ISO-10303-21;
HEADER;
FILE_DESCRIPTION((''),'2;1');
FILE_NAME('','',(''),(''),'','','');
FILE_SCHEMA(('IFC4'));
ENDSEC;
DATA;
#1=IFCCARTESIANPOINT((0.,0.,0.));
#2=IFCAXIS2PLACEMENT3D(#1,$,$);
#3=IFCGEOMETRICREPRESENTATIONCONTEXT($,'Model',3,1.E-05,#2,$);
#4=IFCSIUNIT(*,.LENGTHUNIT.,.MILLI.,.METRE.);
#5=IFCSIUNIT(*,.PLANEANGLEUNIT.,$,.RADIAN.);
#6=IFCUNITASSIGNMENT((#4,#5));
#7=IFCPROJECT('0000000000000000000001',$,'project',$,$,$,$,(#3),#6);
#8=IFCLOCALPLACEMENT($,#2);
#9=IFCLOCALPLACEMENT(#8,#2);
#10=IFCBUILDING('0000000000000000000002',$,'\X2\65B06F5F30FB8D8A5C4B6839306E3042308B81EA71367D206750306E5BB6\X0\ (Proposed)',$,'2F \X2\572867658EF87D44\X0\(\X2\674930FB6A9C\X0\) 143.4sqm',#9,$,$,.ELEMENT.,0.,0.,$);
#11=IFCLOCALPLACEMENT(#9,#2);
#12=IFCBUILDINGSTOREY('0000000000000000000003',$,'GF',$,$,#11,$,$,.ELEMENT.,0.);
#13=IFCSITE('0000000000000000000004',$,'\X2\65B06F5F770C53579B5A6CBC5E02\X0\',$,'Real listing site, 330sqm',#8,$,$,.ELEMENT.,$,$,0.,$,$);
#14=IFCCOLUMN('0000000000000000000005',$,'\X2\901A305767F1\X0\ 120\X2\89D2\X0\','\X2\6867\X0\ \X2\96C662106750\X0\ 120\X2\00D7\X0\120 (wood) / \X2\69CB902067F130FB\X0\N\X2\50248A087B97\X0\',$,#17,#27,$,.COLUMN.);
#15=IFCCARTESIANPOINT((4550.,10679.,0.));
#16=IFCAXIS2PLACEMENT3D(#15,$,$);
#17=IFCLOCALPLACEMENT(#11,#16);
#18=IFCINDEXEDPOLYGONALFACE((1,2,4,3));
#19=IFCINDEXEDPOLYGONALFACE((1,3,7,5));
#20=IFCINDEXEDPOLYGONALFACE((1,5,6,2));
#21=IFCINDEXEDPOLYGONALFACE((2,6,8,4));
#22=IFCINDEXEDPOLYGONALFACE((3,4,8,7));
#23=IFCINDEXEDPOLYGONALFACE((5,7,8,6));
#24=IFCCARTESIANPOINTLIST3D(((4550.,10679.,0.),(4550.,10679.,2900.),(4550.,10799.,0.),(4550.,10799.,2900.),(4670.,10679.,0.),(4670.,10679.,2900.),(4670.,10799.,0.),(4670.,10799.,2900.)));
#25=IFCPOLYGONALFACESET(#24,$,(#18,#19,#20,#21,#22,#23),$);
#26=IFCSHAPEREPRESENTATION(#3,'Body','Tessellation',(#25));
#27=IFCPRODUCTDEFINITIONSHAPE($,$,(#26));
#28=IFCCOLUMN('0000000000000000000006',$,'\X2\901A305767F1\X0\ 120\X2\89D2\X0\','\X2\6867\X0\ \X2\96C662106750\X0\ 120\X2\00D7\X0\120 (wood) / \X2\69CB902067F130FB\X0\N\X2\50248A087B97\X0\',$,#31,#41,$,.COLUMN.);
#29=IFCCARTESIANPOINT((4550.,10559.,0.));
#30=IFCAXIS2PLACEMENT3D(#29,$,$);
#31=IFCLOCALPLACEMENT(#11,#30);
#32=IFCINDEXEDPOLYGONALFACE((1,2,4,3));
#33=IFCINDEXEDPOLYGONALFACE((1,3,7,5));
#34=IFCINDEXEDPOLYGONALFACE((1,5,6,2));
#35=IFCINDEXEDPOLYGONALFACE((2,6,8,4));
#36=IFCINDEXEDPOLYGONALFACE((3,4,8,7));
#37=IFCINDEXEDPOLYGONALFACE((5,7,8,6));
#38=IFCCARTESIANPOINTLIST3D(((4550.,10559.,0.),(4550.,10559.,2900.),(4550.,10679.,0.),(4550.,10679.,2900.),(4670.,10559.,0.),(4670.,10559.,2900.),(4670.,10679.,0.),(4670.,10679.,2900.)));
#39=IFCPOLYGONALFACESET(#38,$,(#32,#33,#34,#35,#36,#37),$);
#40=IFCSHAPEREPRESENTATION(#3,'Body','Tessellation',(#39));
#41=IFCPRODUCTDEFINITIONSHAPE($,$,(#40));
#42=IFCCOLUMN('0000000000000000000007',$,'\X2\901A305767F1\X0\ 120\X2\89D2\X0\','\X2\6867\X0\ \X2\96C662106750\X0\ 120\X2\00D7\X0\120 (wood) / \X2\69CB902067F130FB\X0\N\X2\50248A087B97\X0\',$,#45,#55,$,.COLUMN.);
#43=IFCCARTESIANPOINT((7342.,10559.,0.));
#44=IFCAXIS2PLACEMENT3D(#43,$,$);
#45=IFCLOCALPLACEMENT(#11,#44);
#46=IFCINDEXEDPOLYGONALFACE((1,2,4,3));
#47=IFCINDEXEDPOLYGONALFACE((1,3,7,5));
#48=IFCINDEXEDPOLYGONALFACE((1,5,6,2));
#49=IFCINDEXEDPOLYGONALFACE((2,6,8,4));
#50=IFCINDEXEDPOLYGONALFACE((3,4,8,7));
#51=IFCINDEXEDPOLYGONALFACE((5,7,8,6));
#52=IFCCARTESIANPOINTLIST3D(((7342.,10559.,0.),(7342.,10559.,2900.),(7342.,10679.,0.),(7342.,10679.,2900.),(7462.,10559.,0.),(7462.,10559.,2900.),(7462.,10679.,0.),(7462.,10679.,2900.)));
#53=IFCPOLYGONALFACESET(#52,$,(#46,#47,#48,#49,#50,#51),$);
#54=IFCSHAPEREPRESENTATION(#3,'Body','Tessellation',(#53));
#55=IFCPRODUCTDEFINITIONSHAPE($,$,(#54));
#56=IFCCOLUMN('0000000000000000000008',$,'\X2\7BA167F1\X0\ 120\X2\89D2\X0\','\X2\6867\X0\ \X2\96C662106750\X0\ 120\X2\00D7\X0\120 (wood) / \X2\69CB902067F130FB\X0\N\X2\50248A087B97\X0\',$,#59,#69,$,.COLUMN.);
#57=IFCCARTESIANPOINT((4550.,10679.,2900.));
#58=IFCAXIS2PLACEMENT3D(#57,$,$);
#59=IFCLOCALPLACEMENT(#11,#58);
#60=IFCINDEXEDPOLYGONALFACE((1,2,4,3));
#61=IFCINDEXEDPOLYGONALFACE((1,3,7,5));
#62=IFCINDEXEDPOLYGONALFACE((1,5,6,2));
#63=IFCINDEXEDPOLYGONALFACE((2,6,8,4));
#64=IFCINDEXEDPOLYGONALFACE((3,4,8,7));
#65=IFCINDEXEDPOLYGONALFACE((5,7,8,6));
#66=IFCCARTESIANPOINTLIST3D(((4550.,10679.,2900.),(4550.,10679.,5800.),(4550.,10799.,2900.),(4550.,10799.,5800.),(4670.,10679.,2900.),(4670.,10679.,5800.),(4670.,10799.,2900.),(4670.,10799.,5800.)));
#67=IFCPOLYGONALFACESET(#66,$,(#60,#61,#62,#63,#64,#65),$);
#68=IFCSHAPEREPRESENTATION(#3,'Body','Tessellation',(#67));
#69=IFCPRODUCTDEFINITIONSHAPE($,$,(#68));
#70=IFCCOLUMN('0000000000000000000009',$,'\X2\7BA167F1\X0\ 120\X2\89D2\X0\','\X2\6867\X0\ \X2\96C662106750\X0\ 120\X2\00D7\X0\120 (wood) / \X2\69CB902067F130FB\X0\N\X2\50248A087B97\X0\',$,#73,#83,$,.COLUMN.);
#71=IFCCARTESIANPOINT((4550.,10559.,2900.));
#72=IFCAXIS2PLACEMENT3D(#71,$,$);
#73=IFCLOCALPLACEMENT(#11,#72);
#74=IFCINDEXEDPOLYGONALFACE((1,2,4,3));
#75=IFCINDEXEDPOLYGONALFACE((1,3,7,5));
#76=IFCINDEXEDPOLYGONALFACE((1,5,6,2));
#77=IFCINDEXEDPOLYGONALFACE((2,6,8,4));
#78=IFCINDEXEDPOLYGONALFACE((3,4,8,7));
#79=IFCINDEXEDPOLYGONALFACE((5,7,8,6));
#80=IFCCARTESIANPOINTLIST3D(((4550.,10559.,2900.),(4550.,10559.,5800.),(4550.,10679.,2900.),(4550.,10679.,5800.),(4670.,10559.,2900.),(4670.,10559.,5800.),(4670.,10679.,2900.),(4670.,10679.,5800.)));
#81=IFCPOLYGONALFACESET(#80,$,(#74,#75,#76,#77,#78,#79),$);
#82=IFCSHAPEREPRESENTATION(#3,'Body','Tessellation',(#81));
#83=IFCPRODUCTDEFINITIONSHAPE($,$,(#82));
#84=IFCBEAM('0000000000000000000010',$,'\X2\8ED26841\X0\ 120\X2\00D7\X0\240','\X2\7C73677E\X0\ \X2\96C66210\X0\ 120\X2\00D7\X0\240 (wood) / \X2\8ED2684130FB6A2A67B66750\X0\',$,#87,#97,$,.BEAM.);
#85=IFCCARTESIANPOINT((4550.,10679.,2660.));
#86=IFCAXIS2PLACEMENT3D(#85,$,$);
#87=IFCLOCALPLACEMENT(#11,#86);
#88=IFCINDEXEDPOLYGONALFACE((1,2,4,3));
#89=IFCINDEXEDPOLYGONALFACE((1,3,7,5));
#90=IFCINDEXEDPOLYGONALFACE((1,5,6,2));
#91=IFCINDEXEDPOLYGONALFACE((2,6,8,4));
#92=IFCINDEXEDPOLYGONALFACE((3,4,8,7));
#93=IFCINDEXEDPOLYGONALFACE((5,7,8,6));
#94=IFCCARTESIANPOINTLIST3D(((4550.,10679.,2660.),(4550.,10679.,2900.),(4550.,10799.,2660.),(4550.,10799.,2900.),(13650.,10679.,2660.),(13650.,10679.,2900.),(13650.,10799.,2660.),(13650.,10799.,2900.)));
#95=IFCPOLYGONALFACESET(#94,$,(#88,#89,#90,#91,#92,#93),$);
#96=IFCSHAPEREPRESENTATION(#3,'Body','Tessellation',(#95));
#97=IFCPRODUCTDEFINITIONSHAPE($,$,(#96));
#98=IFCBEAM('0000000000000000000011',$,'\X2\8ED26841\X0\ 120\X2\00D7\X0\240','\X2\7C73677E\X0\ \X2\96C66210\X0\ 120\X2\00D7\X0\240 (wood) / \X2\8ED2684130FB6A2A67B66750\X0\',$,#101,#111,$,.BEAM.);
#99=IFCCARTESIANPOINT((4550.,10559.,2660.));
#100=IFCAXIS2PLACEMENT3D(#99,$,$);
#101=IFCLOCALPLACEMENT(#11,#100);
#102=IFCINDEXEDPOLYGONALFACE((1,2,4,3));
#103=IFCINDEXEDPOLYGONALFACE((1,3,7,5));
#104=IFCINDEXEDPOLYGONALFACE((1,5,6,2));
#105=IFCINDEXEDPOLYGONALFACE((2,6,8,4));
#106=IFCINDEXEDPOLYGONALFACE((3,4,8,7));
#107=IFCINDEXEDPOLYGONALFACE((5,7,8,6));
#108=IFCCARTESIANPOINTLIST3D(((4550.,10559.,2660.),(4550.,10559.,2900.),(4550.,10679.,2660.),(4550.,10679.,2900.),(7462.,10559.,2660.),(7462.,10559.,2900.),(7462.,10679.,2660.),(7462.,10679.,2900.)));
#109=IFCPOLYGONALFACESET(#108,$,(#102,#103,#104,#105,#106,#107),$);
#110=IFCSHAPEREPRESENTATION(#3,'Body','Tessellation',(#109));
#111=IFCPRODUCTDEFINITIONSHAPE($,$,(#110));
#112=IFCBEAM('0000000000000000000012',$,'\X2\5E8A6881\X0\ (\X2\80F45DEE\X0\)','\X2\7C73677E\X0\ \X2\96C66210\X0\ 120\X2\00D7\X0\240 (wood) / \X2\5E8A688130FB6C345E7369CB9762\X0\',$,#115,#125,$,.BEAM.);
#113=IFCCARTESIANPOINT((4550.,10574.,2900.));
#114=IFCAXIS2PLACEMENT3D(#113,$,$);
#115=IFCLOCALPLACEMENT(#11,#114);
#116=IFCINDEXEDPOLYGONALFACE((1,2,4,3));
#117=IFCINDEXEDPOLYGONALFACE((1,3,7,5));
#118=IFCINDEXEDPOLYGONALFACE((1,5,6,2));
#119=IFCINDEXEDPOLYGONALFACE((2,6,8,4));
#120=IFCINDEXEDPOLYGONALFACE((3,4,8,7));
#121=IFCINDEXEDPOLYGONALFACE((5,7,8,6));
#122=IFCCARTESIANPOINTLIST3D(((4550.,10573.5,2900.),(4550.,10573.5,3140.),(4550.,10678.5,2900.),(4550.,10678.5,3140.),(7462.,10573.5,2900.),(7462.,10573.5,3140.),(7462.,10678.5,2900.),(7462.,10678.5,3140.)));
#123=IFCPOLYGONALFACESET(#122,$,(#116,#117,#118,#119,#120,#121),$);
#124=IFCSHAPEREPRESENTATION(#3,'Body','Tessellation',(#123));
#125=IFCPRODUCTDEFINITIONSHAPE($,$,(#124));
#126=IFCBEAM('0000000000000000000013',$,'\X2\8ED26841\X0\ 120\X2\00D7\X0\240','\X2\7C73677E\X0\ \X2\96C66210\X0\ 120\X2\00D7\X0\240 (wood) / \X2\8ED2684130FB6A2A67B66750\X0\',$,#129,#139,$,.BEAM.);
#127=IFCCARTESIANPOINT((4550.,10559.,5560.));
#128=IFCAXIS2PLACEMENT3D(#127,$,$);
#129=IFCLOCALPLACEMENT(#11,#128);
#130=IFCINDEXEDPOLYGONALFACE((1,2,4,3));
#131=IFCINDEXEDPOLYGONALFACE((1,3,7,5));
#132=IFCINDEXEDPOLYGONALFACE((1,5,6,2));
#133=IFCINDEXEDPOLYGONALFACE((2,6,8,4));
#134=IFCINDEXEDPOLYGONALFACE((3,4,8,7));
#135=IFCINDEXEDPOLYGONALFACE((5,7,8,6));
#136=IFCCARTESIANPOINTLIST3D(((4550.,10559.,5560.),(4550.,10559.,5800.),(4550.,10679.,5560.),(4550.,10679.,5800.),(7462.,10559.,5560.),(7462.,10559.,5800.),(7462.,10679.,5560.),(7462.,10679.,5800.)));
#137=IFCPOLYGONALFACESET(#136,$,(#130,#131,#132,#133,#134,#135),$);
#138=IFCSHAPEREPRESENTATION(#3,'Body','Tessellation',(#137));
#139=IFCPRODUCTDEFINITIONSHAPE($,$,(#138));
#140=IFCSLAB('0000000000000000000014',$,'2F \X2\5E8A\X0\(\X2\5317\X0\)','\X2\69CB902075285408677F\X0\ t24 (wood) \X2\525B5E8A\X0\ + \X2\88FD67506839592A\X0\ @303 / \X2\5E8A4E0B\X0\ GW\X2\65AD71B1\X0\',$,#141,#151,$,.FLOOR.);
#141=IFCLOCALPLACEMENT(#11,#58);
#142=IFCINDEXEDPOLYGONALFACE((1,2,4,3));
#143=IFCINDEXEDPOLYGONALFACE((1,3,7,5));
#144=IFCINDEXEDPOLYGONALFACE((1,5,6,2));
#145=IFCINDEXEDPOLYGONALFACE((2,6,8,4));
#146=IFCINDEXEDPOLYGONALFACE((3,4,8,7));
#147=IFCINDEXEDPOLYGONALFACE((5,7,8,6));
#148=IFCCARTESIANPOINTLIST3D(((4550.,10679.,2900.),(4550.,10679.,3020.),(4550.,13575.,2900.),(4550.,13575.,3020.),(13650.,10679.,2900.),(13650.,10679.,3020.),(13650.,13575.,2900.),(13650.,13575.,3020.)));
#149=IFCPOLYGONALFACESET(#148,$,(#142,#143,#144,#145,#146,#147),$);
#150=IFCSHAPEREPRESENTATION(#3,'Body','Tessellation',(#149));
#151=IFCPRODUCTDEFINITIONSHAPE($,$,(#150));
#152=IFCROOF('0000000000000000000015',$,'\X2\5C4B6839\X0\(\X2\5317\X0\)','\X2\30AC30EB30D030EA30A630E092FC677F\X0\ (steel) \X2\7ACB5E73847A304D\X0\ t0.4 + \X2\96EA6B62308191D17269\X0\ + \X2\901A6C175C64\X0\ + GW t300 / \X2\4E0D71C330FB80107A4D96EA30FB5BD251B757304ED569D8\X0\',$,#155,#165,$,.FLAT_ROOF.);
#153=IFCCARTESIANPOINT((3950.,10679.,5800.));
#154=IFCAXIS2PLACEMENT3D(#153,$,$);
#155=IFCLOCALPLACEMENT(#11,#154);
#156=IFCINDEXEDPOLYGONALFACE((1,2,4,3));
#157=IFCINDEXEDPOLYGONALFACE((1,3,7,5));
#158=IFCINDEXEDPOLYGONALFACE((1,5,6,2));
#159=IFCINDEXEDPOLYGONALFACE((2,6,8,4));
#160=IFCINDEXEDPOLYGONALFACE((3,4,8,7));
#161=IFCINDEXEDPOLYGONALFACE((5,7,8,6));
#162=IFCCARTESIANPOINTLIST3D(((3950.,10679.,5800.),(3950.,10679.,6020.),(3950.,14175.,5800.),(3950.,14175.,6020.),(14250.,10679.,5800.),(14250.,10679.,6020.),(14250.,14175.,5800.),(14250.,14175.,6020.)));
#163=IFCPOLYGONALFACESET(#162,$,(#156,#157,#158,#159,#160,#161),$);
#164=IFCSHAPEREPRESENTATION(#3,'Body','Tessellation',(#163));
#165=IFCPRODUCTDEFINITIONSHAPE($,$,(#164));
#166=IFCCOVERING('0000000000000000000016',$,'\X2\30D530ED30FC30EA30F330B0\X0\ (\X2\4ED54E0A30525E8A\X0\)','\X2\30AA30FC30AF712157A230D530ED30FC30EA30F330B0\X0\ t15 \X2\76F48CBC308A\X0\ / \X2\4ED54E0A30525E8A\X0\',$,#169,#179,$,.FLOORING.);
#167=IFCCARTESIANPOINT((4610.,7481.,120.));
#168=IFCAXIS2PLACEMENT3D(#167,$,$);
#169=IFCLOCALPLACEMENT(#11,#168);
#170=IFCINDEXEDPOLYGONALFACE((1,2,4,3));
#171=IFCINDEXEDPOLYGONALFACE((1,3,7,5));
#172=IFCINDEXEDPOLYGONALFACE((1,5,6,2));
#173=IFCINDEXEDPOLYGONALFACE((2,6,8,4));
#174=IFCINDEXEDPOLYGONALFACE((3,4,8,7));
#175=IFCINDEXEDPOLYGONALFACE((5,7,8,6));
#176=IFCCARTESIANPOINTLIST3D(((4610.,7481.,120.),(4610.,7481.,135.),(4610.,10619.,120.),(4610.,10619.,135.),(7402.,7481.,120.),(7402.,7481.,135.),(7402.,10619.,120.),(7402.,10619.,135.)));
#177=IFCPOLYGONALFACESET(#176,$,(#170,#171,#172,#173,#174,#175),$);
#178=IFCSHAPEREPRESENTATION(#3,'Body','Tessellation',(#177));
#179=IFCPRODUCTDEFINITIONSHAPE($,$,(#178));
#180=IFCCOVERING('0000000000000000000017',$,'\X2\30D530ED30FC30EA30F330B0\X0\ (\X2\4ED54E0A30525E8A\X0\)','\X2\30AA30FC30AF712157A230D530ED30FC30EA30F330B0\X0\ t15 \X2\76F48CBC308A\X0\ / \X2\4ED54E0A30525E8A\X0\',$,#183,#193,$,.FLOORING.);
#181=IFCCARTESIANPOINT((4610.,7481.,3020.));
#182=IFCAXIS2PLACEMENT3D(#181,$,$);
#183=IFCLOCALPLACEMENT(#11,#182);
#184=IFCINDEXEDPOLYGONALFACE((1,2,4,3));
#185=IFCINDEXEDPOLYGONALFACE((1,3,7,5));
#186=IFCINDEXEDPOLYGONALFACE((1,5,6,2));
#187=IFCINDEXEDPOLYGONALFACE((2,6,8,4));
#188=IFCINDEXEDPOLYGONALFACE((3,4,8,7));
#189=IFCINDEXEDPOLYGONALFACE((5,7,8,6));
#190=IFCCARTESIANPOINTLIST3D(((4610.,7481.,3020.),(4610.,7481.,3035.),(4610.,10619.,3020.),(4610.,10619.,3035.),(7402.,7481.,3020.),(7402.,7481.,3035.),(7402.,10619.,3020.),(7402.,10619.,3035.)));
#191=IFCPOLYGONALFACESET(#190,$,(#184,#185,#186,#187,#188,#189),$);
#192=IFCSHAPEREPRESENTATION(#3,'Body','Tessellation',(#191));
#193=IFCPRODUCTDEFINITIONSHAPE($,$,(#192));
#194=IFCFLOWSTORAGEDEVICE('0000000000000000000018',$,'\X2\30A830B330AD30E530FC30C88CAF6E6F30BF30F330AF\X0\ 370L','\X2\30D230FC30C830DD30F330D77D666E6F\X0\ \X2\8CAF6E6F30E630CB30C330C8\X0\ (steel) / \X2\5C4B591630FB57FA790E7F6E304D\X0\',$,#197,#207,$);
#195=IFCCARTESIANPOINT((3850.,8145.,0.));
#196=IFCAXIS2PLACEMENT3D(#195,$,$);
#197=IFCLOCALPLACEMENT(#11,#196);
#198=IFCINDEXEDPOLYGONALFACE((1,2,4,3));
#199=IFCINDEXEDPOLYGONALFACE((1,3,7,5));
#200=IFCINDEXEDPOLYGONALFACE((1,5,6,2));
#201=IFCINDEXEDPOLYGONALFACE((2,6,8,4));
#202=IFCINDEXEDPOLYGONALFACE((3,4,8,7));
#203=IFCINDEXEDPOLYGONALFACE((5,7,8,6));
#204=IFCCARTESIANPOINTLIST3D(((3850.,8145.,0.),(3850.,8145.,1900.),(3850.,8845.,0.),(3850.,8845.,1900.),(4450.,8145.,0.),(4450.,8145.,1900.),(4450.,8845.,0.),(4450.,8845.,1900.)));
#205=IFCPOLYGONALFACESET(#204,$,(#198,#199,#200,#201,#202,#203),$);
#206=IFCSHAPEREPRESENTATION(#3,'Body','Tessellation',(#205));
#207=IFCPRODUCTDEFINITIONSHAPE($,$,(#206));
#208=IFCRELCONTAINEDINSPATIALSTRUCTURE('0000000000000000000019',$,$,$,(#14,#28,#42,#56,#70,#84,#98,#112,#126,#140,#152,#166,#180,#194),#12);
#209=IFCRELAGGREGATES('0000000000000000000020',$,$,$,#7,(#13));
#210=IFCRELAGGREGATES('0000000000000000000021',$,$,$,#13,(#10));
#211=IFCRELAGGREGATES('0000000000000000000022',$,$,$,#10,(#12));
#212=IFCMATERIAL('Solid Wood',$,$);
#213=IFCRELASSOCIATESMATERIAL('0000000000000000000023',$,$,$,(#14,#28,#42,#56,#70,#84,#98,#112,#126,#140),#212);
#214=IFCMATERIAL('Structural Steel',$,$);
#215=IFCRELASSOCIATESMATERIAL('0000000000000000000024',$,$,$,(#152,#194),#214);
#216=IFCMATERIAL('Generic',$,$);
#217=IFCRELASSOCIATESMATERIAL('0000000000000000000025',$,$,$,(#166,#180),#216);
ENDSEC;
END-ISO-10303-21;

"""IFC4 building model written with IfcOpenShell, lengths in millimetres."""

from ifc_helpers import new_model, si_unit, frame, frame_2d, origin, place, context, project, spatial, rectangle, extrude, material, element, save


model = new_model("IFC4")

# Units and contexts
model_context = context("Model", 3, precision=1e-05, world=origin())
ifc_project = project(units=[si_unit("LENGTHUNIT", "METRE", prefix="MILLI"), si_unit("PLANEANGLEUNIT", "RADIAN")], contexts=[model_context])

# Site, building, storey
site_placement = place(None, origin())
site = spatial("IfcSite", under=ifc_project, at=site_placement, Name="新潟県南魚沼市", ObjectType="Real listing site, 330sqm", CompositionType="ELEMENT", RefElevation=0.0)
building_placement = place(site_placement, origin())
building = spatial("IfcBuilding", under=site, at=building_placement, Name="新潟・越屋根のある自然素材の家 (Proposed)", ObjectType="2F 在来軸組(杉・檜) 143.4sqm", CompositionType="ELEMENT", ElevationOfRefHeight=0.0, ElevationOfTerrain=0.0)
storey_placement = place(building_placement, origin())
storey = spatial("IfcBuildingStorey", under=building, at=storey_placement, Name="GF", CompositionType="ELEMENT", Elevation=0.0)

# Columns
ifc_material_1 = material(Name="Solid Wood")
column_1_placement = place(storey_placement, frame((4550.0, 10679.0, 0.0)))
element("IfcColumn", 1, at=column_1_placement, inside=storey, material=ifc_material_1, Name="通し柱 120角", Description="桧 集成材 120×120 (wood) / 構造柱・N値計算", PredefinedType="COLUMN", context=model_context, shape_type="SweptSolid", body=[
    extrude(rectangle(XDim=120.0, YDim=120.0, at=frame_2d((60.0, 60.0))), frame((4550.0, 10679.0, 0.0)), (0.0, 0.0, 1.0), 2900.0),
])
column_2_placement = place(storey_placement, frame((4550.0, 10559.0, 0.0)))
element("IfcColumn", 2, at=column_2_placement, inside=storey, material=ifc_material_1, Name="通し柱 120角", Description="桧 集成材 120×120 (wood) / 構造柱・N値計算", PredefinedType="COLUMN", context=model_context, shape_type="SweptSolid", body=[
    extrude(rectangle(XDim=120.0, YDim=120.0, at=frame_2d((60.0, 60.0))), frame((4550.0, 10559.0, 0.0)), (0.0, 0.0, 1.0), 2900.0),
])
column_3_placement = place(storey_placement, frame((7342.0, 10559.0, 0.0)))
element("IfcColumn", 3, at=column_3_placement, inside=storey, material=ifc_material_1, Name="通し柱 120角", Description="桧 集成材 120×120 (wood) / 構造柱・N値計算", PredefinedType="COLUMN", context=model_context, shape_type="SweptSolid", body=[
    extrude(rectangle(XDim=120.0, YDim=120.0, at=frame_2d((60.0, 60.0))), frame((7342.0, 10559.0, 0.0)), (0.0, 0.0, 1.0), 2900.0),
])
column_4_placement = place(storey_placement, frame((4550.0, 10679.0, 2900.0)))
element("IfcColumn", 4, at=column_4_placement, inside=storey, material=ifc_material_1, Name="管柱 120角", Description="桧 集成材 120×120 (wood) / 構造柱・N値計算", PredefinedType="COLUMN", context=model_context, shape_type="SweptSolid", body=[
    extrude(rectangle(XDim=120.0, YDim=120.0, at=frame_2d((60.0, 60.0))), frame((4550.0, 10679.0, 2900.0)), (0.0, 0.0, 1.0), 2900.0),
])
column_5_placement = place(storey_placement, frame((4550.0, 10559.0, 2900.0)))
element("IfcColumn", 5, at=column_5_placement, inside=storey, material=ifc_material_1, Name="管柱 120角", Description="桧 集成材 120×120 (wood) / 構造柱・N値計算", PredefinedType="COLUMN", context=model_context, shape_type="SweptSolid", body=[
    extrude(rectangle(XDim=120.0, YDim=120.0, at=frame_2d((60.0, 60.0))), frame((4550.0, 10559.0, 2900.0)), (0.0, 0.0, 1.0), 2900.0),
])

# Beams
beam_1_placement = place(storey_placement, frame((4550.0, 10679.0, 2660.0)))
element("IfcBeam", 6, at=beam_1_placement, inside=storey, material=ifc_material_1, Name="軒桁 120×240", Description="米松 集成 120×240 (wood) / 軒桁・横架材", PredefinedType="BEAM", context=model_context, shape_type="SweptSolid", body=[
    extrude(rectangle(XDim=9100.0, YDim=120.0, at=frame_2d((4550.0, 60.0))), frame((4550.0, 10679.0, 2660.0)), (0.0, 0.0, 1.0), 240.0),
])
beam_2_placement = place(storey_placement, frame((4550.0, 10559.0, 2660.0)))
element("IfcBeam", 7, at=beam_2_placement, inside=storey, material=ifc_material_1, Name="軒桁 120×240", Description="米松 集成 120×240 (wood) / 軒桁・横架材", PredefinedType="BEAM", context=model_context, shape_type="SweptSolid", body=[
    extrude(rectangle(XDim=2912.0, YDim=120.0, at=frame_2d((1456.0, 60.0))), frame((4550.0, 10559.0, 2660.0)), (0.0, 0.0, 1.0), 240.0),
])
beam_3_placement = place(storey_placement, frame((4550.0, 10574.0, 2900.0)))
element("IfcBeam", 8, at=beam_3_placement, inside=storey, material=ifc_material_1, Name="床梁 (胴差)", Description="米松 集成 120×240 (wood) / 床梁・水平構面", PredefinedType="BEAM", context=model_context, shape_type="SweptSolid", body=[
    extrude(rectangle(XDim=2912.0, YDim=105.0, at=frame_2d((1456.0, 52.0))), frame((4550.0, 10574.0, 2900.0)), (0.0, 0.0, 1.0), 240.0),
])
beam_4_placement = place(storey_placement, frame((4550.0, 10559.0, 5560.0)))
element("IfcBeam", 9, at=beam_4_placement, inside=storey, material=ifc_material_1, Name="軒桁 120×240", Description="米松 集成 120×240 (wood) / 軒桁・横架材", PredefinedType="BEAM", context=model_context, shape_type="SweptSolid", body=[
    extrude(rectangle(XDim=2912.0, YDim=120.0, at=frame_2d((1456.0, 60.0))), frame((4550.0, 10559.0, 5560.0)), (0.0, 0.0, 1.0), 240.0),
])

# Slab
slab_1_placement = place(storey_placement, frame((4550.0, 10679.0, 2900.0)))
element("IfcSlab", 10, at=slab_1_placement, inside=storey, material=ifc_material_1, Name="2F 床(北)", Description="構造用合板 t24 (wood) 剛床 + 製材根太 @303 / 床下 GW断熱", PredefinedType="FLOOR", context=model_context, shape_type="SweptSolid", body=[
    extrude(rectangle(XDim=9100.0, YDim=2896.0, at=frame_2d((4550.0, 1448.0))), frame((4550.0, 10679.0, 2900.0)), (0.0, 0.0, 1.0), 120.0),
])

# Roof
ifc_material_2 = material(Name="Structural Steel")
for number, where, name in (
    (11, (3950.0, 10679.0, 5800.0), "屋根(北)"),
):
    element("IfcRoof", number, at=place(storey_placement, frame(where)), inside=storey, material=ifc_material_2, Name=name, Description="ガルバリウム鋼板 (steel) 立平葺き t0.4 + 雪止め金物 + 通気層 + GW t300 / 不燃・耐積雪・寒冷地仕様", PredefinedType="FLAT_ROOF", context=model_context, shape_type="SweptSolid", body=[
        extrude(rectangle(XDim=10300.0, YDim=3496.0, at=frame_2d((5150.0, 1748.0))), frame((3950.0, 10679.0, 5800.0)), (0.0, 0.0, 1.0), 220.0),
    ])

# Coverings
ifc_material_3 = material(Name="Generic")
covering_1_placement = place(storey_placement, frame((4610.0, 7481.0, 120.0)))
element("IfcCovering", 12, at=covering_1_placement, inside=storey, material=ifc_material_3, Name="フローリング (仕上げ床)", Description="オーク無垢フローリング t15 直貼り / 仕上げ床", PredefinedType="FLOORING", context=model_context, shape_type="SweptSolid", body=[
    extrude(rectangle(XDim=2792.0, YDim=3138.0, at=frame_2d((1396.0, 1569.0))), frame((4610.0, 7481.0, 120.0)), (0.0, 0.0, 1.0), 15.0),
])
covering_2_placement = place(storey_placement, frame((4610.0, 7481.0, 3020.0)))
element("IfcCovering", 13, at=covering_2_placement, inside=storey, material=ifc_material_3, Name="フローリング (仕上げ床)", Description="オーク無垢フローリング t15 直貼り / 仕上げ床", PredefinedType="FLOORING", context=model_context, shape_type="SweptSolid", body=[
    extrude(rectangle(XDim=2792.0, YDim=3138.0, at=frame_2d((1396.0, 1569.0))), frame((4610.0, 7481.0, 3020.0)), (0.0, 0.0, 1.0), 15.0),
])

# Flow storage device
flow_storage_device_placement = place(storey_placement, frame((3850.0, 8145.0, 0.0)))
element("IfcFlowStorageDevice", 14, at=flow_storage_device_placement, inside=storey, material=ifc_material_2, Name="エコキュート貯湯タンク 370L", Description="ヒートポンプ給湯 貯湯ユニット (steel) / 屋外・基礎置き", context=model_context, shape_type="SweptSolid", body=[
    extrude(rectangle(XDim=600.0, YDim=700.0, at=frame_2d((300.0, 350.0))), frame((3850.0, 8145.0, 0.0)), (0.0, 0.0, 1.0), 1900.0),
])

save(model, "model.ifc")
